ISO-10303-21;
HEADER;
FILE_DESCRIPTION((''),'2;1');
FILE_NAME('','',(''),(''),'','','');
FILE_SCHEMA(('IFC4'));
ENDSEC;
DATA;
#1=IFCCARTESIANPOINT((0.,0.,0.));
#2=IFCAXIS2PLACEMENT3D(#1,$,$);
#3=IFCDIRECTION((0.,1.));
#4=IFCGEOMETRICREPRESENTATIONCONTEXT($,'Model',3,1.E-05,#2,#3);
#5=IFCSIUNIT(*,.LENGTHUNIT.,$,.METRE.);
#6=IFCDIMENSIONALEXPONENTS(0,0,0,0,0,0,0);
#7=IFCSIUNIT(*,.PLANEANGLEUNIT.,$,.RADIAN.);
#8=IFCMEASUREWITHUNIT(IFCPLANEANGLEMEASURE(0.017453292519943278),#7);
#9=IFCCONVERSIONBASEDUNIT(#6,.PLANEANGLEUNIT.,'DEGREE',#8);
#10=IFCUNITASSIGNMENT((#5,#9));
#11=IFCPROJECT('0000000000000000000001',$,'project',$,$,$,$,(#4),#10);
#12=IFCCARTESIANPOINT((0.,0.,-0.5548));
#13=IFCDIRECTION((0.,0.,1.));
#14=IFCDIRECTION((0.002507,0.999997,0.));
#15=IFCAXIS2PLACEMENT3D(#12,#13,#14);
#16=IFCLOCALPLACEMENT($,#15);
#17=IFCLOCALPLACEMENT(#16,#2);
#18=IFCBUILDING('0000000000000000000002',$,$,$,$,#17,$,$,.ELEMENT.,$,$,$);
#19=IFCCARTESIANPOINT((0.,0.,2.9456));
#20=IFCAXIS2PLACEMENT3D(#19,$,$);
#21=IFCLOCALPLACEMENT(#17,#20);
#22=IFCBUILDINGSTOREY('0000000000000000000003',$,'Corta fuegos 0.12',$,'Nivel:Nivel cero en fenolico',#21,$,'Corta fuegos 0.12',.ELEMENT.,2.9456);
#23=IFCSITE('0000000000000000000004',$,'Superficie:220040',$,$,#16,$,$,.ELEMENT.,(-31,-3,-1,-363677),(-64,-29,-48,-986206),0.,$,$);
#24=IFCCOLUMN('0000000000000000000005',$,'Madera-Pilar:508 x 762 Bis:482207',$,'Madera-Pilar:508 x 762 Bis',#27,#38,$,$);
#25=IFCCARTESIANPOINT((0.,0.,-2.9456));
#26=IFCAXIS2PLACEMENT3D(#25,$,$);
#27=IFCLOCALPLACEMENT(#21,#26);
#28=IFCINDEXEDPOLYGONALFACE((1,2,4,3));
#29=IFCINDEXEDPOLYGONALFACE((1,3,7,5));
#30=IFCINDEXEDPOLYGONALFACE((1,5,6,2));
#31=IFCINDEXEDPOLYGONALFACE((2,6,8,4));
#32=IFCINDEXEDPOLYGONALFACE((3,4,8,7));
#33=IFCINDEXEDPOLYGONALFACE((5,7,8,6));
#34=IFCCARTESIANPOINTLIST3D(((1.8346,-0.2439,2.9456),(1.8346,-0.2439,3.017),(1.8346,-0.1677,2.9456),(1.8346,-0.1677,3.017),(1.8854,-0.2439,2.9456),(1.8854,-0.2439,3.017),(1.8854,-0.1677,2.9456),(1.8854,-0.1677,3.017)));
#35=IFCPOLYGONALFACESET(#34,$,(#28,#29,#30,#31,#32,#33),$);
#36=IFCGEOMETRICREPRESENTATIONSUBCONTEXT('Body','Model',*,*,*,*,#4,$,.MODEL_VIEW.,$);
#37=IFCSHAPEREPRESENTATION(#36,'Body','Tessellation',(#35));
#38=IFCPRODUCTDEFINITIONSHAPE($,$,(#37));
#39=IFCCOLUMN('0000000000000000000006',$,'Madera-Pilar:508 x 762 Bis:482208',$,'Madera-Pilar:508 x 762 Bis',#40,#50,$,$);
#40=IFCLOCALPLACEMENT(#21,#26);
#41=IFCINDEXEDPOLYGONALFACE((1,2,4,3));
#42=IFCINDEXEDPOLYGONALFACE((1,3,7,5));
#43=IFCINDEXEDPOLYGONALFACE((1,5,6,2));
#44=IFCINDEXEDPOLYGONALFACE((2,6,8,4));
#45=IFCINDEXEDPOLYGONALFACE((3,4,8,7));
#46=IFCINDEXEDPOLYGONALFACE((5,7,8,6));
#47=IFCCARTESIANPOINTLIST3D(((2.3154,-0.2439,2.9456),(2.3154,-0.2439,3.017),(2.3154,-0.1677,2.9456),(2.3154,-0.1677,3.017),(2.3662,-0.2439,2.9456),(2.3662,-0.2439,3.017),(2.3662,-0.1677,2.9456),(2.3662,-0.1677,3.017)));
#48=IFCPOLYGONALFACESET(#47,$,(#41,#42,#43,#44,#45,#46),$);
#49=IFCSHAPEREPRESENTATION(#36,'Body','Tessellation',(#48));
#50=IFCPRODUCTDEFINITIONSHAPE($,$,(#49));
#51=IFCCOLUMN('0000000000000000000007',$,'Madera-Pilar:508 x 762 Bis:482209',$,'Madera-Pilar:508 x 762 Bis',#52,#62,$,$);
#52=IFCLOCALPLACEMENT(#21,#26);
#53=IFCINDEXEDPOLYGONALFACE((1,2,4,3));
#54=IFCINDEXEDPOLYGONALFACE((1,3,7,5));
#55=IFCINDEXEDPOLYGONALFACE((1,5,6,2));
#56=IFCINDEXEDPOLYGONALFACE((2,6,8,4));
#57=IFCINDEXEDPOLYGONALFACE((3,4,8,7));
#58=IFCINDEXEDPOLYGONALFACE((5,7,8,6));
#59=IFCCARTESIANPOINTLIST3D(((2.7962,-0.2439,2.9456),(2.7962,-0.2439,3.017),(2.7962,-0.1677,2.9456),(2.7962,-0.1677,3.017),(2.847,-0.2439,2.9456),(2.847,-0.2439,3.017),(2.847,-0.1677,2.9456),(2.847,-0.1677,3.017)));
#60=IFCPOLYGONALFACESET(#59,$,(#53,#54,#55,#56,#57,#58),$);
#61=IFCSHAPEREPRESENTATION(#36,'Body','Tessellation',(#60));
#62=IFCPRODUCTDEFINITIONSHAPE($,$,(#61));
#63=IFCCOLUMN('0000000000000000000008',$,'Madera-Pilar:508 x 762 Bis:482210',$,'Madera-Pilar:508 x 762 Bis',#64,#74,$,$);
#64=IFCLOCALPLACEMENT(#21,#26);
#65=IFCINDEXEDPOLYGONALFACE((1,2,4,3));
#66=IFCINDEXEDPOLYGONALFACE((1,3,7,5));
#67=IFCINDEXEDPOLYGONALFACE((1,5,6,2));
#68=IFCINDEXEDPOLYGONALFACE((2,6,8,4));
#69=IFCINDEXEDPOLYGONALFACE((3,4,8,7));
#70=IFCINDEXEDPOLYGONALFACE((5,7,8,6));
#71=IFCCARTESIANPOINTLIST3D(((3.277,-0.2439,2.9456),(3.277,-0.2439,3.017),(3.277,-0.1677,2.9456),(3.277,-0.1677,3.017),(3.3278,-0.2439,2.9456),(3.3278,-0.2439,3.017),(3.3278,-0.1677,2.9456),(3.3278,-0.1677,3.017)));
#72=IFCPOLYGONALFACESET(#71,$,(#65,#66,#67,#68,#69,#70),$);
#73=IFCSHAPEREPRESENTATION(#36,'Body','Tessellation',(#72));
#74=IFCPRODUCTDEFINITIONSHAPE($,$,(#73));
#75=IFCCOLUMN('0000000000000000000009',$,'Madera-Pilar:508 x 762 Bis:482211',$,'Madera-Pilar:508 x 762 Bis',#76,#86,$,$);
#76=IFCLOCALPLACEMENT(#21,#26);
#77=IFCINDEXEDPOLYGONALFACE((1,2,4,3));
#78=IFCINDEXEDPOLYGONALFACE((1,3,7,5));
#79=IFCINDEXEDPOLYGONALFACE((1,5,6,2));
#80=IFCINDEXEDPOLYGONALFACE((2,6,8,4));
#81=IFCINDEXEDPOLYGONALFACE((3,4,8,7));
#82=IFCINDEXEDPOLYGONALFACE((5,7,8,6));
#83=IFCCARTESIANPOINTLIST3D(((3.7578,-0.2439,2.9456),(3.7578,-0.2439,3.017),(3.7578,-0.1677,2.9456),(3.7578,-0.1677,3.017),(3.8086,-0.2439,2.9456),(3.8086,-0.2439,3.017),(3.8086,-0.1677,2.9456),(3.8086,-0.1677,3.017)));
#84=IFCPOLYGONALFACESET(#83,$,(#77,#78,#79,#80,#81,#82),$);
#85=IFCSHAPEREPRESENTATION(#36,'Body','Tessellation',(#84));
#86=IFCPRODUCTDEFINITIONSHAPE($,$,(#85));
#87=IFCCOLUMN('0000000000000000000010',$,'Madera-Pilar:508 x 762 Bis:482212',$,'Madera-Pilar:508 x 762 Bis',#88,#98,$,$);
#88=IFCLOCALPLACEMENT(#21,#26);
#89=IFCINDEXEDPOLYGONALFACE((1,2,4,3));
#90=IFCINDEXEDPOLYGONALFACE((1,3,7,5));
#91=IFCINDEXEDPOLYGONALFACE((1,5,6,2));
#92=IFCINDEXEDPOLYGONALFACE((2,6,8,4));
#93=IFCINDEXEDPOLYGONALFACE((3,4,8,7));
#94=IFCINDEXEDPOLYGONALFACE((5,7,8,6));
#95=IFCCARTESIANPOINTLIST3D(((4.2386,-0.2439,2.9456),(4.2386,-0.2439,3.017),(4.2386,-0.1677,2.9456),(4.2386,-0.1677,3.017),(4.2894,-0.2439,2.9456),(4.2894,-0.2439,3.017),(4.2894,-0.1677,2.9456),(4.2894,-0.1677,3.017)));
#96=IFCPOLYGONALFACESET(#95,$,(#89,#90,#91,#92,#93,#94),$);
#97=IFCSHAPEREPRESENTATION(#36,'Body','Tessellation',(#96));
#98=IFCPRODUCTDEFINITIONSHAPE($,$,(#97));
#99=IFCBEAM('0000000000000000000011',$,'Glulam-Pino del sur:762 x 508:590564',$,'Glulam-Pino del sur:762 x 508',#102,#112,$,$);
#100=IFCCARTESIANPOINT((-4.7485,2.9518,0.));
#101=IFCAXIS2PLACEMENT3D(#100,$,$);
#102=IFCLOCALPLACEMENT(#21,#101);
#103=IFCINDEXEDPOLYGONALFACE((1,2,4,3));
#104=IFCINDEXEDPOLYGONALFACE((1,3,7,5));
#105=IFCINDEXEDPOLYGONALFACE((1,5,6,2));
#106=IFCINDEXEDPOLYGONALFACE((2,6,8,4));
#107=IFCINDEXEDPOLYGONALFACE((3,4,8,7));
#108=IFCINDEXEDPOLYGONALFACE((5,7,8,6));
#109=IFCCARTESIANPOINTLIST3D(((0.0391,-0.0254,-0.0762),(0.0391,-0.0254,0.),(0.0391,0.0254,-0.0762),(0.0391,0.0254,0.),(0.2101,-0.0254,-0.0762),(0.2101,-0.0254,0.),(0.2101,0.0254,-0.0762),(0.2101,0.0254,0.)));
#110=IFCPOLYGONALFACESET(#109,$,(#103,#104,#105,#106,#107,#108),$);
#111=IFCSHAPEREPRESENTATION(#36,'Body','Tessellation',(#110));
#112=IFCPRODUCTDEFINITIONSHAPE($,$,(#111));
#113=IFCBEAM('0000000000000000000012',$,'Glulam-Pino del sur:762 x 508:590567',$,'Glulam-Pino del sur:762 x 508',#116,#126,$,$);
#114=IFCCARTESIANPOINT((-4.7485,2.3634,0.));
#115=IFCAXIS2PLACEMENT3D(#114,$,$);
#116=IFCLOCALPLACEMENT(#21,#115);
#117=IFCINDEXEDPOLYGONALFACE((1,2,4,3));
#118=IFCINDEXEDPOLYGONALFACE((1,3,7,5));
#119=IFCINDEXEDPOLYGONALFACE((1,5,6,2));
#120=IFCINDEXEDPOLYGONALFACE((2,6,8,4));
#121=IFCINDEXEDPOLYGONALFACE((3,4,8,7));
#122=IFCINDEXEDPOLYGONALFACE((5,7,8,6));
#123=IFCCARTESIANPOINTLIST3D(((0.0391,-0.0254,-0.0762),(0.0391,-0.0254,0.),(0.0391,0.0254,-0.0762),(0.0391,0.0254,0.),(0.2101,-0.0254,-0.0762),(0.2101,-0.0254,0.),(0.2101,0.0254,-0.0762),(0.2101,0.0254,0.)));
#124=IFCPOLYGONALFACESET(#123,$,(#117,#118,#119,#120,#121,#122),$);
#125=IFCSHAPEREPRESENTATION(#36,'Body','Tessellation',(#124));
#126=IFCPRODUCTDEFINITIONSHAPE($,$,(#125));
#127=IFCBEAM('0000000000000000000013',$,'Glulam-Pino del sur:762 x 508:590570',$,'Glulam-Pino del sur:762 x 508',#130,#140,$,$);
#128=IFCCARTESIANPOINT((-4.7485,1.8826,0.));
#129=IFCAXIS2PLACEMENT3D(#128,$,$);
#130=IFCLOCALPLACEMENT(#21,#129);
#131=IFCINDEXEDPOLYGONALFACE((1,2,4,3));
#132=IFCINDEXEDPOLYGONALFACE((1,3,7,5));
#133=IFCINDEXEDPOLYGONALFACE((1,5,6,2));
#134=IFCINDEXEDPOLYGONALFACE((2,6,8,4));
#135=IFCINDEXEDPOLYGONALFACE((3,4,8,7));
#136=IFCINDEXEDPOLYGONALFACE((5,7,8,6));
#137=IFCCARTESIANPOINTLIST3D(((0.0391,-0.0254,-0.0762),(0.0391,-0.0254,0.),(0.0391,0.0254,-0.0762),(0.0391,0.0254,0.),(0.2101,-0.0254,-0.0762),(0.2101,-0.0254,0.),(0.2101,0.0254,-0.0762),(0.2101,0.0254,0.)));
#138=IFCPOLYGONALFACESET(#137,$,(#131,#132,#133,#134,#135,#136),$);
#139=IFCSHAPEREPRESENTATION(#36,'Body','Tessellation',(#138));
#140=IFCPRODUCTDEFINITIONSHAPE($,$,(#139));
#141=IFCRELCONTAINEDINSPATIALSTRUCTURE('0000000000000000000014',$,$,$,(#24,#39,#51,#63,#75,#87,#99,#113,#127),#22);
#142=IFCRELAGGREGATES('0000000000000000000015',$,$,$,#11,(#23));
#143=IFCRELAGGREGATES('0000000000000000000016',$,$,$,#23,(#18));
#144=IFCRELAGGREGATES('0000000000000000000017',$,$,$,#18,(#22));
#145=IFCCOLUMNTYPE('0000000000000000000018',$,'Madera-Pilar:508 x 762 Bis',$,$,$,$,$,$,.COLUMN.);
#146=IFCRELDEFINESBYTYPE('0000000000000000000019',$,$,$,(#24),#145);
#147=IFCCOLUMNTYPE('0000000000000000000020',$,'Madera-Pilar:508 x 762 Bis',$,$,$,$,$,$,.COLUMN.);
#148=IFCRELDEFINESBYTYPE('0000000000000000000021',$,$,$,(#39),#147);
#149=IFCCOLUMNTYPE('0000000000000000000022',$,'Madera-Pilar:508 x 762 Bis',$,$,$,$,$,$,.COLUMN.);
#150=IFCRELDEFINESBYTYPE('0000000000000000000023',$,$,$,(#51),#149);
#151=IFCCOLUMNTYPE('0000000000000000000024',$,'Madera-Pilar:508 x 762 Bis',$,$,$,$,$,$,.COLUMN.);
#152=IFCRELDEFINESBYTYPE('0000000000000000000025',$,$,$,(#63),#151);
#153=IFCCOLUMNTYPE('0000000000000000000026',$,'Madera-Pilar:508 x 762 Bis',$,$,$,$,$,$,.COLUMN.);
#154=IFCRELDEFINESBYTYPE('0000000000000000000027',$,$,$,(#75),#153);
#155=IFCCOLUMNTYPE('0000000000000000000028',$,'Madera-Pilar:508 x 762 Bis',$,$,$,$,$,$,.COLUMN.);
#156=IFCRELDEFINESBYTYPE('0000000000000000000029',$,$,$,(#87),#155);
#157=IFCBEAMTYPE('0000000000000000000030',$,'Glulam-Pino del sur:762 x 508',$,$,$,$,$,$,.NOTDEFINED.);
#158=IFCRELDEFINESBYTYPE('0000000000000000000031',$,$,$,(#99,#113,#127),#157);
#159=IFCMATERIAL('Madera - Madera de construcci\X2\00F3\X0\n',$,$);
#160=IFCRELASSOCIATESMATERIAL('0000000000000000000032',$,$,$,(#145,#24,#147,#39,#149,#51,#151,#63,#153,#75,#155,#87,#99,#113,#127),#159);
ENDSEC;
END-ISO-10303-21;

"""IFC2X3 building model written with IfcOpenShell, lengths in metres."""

from ifc_helpers import new_model, entity, si_unit, converted_unit, direction, frame, frame_2d, origin, origin_2d_with_axis, place, context, subcontext, project, spatial, rectangle, extrude, source, transform, mapped, material, type_object, type_shapes, element, save


model = new_model("IFC2X3")

# Units and contexts
model_context = context("Model", 3, precision=1e-05, world=origin(), true_north=direction((0.0, 1.0)))
body_context = subcontext(model_context, "Body", "Model", "MODEL_VIEW")
ifc_project = project(units=[si_unit("LENGTHUNIT", "METRE"), converted_unit("PLANEANGLEUNIT", "DEGREE", entity("IfcPlaneAngleMeasure", 0.017453292519943278), si_unit("PLANEANGLEUNIT", "RADIAN"), dimensions=[0, 0, 0, 0, 0, 0, 0])], contexts=[model_context])

# Site, building, storey
site_placement = place(None, frame((0.0, 0.0, -0.5548), z_axis=(0.0, 0.0, 1.0), x_axis=(0.002507, 0.999997, 0.0)))
site = spatial("IfcSite", under=ifc_project, at=site_placement, Name="Superficie:220040", CompositionType="ELEMENT", RefLatitude=(-31, -3, -1, -363677), RefLongitude=(-64, -29, -48, -986206), RefElevation=0.0)
building_placement = place(site_placement, origin())
building = spatial("IfcBuilding", under=site, at=building_placement, CompositionType="ELEMENT")
storey_placement = place(building_placement, frame((0.0, 0.0, 2.9456)))
storey = spatial("IfcBuildingStorey", under=building, at=storey_placement, Name="Corta fuegos 0.12", ObjectType="Nivel:Nivel cero en fenolico", LongName="Corta fuegos 0.12", CompositionType="ELEMENT", Elevation=2.9456)

# Columns
ifc_material_1 = material(Name="Madera - Madera de construcción")
column_type_1 = type_object("IfcColumnType", Name="Madera-Pilar:508 x 762 Bis", PredefinedType="COLUMN", material=ifc_material_1)
shared_shape_1 = source(origin(), body_context, "Body", "SweptSolid", [
    extrude(rectangle(XDim=0.0508, YDim=0.0762, at=frame_2d((0.0, 0.0), x_axis=(1.0, 0.0))), frame((1.86, -0.2058, 2.9456), z_axis=(0.0, 0.0, 1.0), x_axis=(-1.0, 0.0, 0.0)), (0.0, 0.0, 1.0), 0.0714),
])
type_shapes(column_type_1, [shared_shape_1])
column_1_placement = place(storey_placement, frame((0.0, 0.0, -2.9456)))
element("IfcColumn", 1, at=column_1_placement, inside=storey, type_object=column_type_1, material=ifc_material_1, Name="Madera-Pilar:508 x 762 Bis:482207", ObjectType="Madera-Pilar:508 x 762 Bis", context=body_context, shape_type="MappedRepresentation", body=[
    mapped(shared_shape_1, transform((0.0, 0.0, 0.0), scale=1.0)),
])
column_type_2 = type_object("IfcColumnType", Name="Madera-Pilar:508 x 762 Bis", PredefinedType="COLUMN", material=ifc_material_1)
shared_shape_2 = source(origin(), body_context, "Body", "SweptSolid", [
    extrude(rectangle(XDim=0.0508, YDim=0.0762, at=frame_2d((0.0, 0.0), x_axis=(1.0, 0.0))), frame((2.3408, -0.2058, 2.9456), z_axis=(0.0, 0.0, 1.0), x_axis=(-1.0, 0.0, 0.0)), (0.0, 0.0, 1.0), 0.0714),
])
type_shapes(column_type_2, [shared_shape_2])
column_2_placement = place(storey_placement, frame((0.0, 0.0, -2.9456)))
element("IfcColumn", 2, at=column_2_placement, inside=storey, type_object=column_type_2, material=ifc_material_1, Name="Madera-Pilar:508 x 762 Bis:482208", ObjectType="Madera-Pilar:508 x 762 Bis", context=body_context, shape_type="MappedRepresentation", body=[
    mapped(shared_shape_2, transform((0.0, 0.0, 0.0), scale=1.0)),
])
column_type_3 = type_object("IfcColumnType", Name="Madera-Pilar:508 x 762 Bis", PredefinedType="COLUMN", material=ifc_material_1)
shared_shape_3 = source(origin(), body_context, "Body", "SweptSolid", [
    extrude(rectangle(XDim=0.0508, YDim=0.0762, at=frame_2d((0.0, 0.0), x_axis=(1.0, 0.0))), frame((2.8216, -0.2058, 2.9456), z_axis=(0.0, 0.0, 1.0), x_axis=(-1.0, 0.0, 0.0)), (0.0, 0.0, 1.0), 0.0714),
])
type_shapes(column_type_3, [shared_shape_3])
column_3_placement = place(storey_placement, frame((0.0, 0.0, -2.9456)))
element("IfcColumn", 3, at=column_3_placement, inside=storey, type_object=column_type_3, material=ifc_material_1, Name="Madera-Pilar:508 x 762 Bis:482209", ObjectType="Madera-Pilar:508 x 762 Bis", context=body_context, shape_type="MappedRepresentation", body=[
    mapped(shared_shape_3, transform((0.0, 0.0, 0.0), scale=1.0)),
])
column_type_4 = type_object("IfcColumnType", Name="Madera-Pilar:508 x 762 Bis", PredefinedType="COLUMN", material=ifc_material_1)
shared_shape_4 = source(origin(), body_context, "Body", "SweptSolid", [
    extrude(rectangle(XDim=0.0508, YDim=0.0762, at=frame_2d((0.0, 0.0), x_axis=(1.0, 0.0))), frame((3.3024, -0.2058, 2.9456), z_axis=(0.0, 0.0, 1.0), x_axis=(-1.0, 0.0, 0.0)), (0.0, 0.0, 1.0), 0.0714),
])
type_shapes(column_type_4, [shared_shape_4])
column_4_placement = place(storey_placement, frame((0.0, 0.0, -2.9456)))
element("IfcColumn", 4, at=column_4_placement, inside=storey, type_object=column_type_4, material=ifc_material_1, Name="Madera-Pilar:508 x 762 Bis:482210", ObjectType="Madera-Pilar:508 x 762 Bis", context=body_context, shape_type="MappedRepresentation", body=[
    mapped(shared_shape_4, transform((0.0, 0.0, 0.0), scale=1.0)),
])
column_type_5 = type_object("IfcColumnType", Name="Madera-Pilar:508 x 762 Bis", PredefinedType="COLUMN", material=ifc_material_1)
shared_shape_5 = source(origin(), body_context, "Body", "SweptSolid", [
    extrude(rectangle(XDim=0.0508, YDim=0.0762, at=frame_2d((0.0, 0.0), x_axis=(1.0, 0.0))), frame((3.7832, -0.2058, 2.9456), z_axis=(0.0, 0.0, 1.0), x_axis=(-1.0, 0.0, 0.0)), (0.0, 0.0, 1.0), 0.0714),
])
type_shapes(column_type_5, [shared_shape_5])
column_5_placement = place(storey_placement, frame((0.0, 0.0, -2.9456)))
element("IfcColumn", 5, at=column_5_placement, inside=storey, type_object=column_type_5, material=ifc_material_1, Name="Madera-Pilar:508 x 762 Bis:482211", ObjectType="Madera-Pilar:508 x 762 Bis", context=body_context, shape_type="MappedRepresentation", body=[
    mapped(shared_shape_5, transform((0.0, 0.0, 0.0), scale=1.0)),
])
column_type_6 = type_object("IfcColumnType", Name="Madera-Pilar:508 x 762 Bis", PredefinedType="COLUMN", material=ifc_material_1)
shared_shape_6 = source(origin(), body_context, "Body", "SweptSolid", [
    extrude(rectangle(XDim=0.0508, YDim=0.0762, at=frame_2d((0.0, 0.0), x_axis=(1.0, 0.0))), frame((4.264, -0.2058, 2.9456), z_axis=(0.0, 0.0, 1.0), x_axis=(-1.0, 0.0, 0.0)), (0.0, 0.0, 1.0), 0.0714),
])
type_shapes(column_type_6, [shared_shape_6])
column_6_placement = place(storey_placement, frame((0.0, 0.0, -2.9456)))
element("IfcColumn", 6, at=column_6_placement, inside=storey, type_object=column_type_6, material=ifc_material_1, Name="Madera-Pilar:508 x 762 Bis:482212", ObjectType="Madera-Pilar:508 x 762 Bis", context=body_context, shape_type="MappedRepresentation", body=[
    mapped(shared_shape_6, transform((0.0, 0.0, 0.0), scale=1.0)),
])

# Beams
beam_type = type_object("IfcBeamType", Name="Glulam-Pino del sur:762 x 508", PredefinedType="NOTDEFINED")
beam_1_placement = place(storey_placement, frame((-4.7485, 2.9518, 0.0)))
element("IfcBeam", 7, at=beam_1_placement, inside=storey, type_object=beam_type, material=ifc_material_1, Name="Glulam-Pino del sur:762 x 508:590564", ObjectType="Glulam-Pino del sur:762 x 508", context=body_context, shape_type="SweptSolid", body=[
    extrude(rectangle(XDim=0.0762, YDim=0.0508, at=origin_2d_with_axis()), frame((0.0391, 0.0, -0.0381), z_axis=(1.0, 0.0, 0.0), x_axis=(0.0, 0.0, -1.0)), (0.0, 0.0, 1.0), 0.171),
])
beam_2_placement = place(storey_placement, frame((-4.7485, 2.3634, 0.0)))
element("IfcBeam", 8, at=beam_2_placement, inside=storey, type_object=beam_type, material=ifc_material_1, Name="Glulam-Pino del sur:762 x 508:590567", ObjectType="Glulam-Pino del sur:762 x 508", context=body_context, shape_type="SweptSolid", body=[
    extrude(rectangle(XDim=0.0762, YDim=0.0508, at=origin_2d_with_axis()), frame((0.0391, 0.0, -0.0381), z_axis=(1.0, 0.0, 0.0), x_axis=(0.0, 0.0, -1.0)), (0.0, 0.0, 1.0), 0.171),
])
beam_3_placement = place(storey_placement, frame((-4.7485, 1.8826, 0.0)))
element("IfcBeam", 9, at=beam_3_placement, inside=storey, type_object=beam_type, material=ifc_material_1, Name="Glulam-Pino del sur:762 x 508:590570", ObjectType="Glulam-Pino del sur:762 x 508", context=body_context, shape_type="SweptSolid", body=[
    extrude(rectangle(XDim=0.0762, YDim=0.0508, at=origin_2d_with_axis()), frame((0.0391, 0.0, -0.0381), z_axis=(1.0, 0.0, 0.0), x_axis=(0.0, 0.0, -1.0)), (0.0, 0.0, 1.0), 0.171),
])

save(model, "model.ifc")
